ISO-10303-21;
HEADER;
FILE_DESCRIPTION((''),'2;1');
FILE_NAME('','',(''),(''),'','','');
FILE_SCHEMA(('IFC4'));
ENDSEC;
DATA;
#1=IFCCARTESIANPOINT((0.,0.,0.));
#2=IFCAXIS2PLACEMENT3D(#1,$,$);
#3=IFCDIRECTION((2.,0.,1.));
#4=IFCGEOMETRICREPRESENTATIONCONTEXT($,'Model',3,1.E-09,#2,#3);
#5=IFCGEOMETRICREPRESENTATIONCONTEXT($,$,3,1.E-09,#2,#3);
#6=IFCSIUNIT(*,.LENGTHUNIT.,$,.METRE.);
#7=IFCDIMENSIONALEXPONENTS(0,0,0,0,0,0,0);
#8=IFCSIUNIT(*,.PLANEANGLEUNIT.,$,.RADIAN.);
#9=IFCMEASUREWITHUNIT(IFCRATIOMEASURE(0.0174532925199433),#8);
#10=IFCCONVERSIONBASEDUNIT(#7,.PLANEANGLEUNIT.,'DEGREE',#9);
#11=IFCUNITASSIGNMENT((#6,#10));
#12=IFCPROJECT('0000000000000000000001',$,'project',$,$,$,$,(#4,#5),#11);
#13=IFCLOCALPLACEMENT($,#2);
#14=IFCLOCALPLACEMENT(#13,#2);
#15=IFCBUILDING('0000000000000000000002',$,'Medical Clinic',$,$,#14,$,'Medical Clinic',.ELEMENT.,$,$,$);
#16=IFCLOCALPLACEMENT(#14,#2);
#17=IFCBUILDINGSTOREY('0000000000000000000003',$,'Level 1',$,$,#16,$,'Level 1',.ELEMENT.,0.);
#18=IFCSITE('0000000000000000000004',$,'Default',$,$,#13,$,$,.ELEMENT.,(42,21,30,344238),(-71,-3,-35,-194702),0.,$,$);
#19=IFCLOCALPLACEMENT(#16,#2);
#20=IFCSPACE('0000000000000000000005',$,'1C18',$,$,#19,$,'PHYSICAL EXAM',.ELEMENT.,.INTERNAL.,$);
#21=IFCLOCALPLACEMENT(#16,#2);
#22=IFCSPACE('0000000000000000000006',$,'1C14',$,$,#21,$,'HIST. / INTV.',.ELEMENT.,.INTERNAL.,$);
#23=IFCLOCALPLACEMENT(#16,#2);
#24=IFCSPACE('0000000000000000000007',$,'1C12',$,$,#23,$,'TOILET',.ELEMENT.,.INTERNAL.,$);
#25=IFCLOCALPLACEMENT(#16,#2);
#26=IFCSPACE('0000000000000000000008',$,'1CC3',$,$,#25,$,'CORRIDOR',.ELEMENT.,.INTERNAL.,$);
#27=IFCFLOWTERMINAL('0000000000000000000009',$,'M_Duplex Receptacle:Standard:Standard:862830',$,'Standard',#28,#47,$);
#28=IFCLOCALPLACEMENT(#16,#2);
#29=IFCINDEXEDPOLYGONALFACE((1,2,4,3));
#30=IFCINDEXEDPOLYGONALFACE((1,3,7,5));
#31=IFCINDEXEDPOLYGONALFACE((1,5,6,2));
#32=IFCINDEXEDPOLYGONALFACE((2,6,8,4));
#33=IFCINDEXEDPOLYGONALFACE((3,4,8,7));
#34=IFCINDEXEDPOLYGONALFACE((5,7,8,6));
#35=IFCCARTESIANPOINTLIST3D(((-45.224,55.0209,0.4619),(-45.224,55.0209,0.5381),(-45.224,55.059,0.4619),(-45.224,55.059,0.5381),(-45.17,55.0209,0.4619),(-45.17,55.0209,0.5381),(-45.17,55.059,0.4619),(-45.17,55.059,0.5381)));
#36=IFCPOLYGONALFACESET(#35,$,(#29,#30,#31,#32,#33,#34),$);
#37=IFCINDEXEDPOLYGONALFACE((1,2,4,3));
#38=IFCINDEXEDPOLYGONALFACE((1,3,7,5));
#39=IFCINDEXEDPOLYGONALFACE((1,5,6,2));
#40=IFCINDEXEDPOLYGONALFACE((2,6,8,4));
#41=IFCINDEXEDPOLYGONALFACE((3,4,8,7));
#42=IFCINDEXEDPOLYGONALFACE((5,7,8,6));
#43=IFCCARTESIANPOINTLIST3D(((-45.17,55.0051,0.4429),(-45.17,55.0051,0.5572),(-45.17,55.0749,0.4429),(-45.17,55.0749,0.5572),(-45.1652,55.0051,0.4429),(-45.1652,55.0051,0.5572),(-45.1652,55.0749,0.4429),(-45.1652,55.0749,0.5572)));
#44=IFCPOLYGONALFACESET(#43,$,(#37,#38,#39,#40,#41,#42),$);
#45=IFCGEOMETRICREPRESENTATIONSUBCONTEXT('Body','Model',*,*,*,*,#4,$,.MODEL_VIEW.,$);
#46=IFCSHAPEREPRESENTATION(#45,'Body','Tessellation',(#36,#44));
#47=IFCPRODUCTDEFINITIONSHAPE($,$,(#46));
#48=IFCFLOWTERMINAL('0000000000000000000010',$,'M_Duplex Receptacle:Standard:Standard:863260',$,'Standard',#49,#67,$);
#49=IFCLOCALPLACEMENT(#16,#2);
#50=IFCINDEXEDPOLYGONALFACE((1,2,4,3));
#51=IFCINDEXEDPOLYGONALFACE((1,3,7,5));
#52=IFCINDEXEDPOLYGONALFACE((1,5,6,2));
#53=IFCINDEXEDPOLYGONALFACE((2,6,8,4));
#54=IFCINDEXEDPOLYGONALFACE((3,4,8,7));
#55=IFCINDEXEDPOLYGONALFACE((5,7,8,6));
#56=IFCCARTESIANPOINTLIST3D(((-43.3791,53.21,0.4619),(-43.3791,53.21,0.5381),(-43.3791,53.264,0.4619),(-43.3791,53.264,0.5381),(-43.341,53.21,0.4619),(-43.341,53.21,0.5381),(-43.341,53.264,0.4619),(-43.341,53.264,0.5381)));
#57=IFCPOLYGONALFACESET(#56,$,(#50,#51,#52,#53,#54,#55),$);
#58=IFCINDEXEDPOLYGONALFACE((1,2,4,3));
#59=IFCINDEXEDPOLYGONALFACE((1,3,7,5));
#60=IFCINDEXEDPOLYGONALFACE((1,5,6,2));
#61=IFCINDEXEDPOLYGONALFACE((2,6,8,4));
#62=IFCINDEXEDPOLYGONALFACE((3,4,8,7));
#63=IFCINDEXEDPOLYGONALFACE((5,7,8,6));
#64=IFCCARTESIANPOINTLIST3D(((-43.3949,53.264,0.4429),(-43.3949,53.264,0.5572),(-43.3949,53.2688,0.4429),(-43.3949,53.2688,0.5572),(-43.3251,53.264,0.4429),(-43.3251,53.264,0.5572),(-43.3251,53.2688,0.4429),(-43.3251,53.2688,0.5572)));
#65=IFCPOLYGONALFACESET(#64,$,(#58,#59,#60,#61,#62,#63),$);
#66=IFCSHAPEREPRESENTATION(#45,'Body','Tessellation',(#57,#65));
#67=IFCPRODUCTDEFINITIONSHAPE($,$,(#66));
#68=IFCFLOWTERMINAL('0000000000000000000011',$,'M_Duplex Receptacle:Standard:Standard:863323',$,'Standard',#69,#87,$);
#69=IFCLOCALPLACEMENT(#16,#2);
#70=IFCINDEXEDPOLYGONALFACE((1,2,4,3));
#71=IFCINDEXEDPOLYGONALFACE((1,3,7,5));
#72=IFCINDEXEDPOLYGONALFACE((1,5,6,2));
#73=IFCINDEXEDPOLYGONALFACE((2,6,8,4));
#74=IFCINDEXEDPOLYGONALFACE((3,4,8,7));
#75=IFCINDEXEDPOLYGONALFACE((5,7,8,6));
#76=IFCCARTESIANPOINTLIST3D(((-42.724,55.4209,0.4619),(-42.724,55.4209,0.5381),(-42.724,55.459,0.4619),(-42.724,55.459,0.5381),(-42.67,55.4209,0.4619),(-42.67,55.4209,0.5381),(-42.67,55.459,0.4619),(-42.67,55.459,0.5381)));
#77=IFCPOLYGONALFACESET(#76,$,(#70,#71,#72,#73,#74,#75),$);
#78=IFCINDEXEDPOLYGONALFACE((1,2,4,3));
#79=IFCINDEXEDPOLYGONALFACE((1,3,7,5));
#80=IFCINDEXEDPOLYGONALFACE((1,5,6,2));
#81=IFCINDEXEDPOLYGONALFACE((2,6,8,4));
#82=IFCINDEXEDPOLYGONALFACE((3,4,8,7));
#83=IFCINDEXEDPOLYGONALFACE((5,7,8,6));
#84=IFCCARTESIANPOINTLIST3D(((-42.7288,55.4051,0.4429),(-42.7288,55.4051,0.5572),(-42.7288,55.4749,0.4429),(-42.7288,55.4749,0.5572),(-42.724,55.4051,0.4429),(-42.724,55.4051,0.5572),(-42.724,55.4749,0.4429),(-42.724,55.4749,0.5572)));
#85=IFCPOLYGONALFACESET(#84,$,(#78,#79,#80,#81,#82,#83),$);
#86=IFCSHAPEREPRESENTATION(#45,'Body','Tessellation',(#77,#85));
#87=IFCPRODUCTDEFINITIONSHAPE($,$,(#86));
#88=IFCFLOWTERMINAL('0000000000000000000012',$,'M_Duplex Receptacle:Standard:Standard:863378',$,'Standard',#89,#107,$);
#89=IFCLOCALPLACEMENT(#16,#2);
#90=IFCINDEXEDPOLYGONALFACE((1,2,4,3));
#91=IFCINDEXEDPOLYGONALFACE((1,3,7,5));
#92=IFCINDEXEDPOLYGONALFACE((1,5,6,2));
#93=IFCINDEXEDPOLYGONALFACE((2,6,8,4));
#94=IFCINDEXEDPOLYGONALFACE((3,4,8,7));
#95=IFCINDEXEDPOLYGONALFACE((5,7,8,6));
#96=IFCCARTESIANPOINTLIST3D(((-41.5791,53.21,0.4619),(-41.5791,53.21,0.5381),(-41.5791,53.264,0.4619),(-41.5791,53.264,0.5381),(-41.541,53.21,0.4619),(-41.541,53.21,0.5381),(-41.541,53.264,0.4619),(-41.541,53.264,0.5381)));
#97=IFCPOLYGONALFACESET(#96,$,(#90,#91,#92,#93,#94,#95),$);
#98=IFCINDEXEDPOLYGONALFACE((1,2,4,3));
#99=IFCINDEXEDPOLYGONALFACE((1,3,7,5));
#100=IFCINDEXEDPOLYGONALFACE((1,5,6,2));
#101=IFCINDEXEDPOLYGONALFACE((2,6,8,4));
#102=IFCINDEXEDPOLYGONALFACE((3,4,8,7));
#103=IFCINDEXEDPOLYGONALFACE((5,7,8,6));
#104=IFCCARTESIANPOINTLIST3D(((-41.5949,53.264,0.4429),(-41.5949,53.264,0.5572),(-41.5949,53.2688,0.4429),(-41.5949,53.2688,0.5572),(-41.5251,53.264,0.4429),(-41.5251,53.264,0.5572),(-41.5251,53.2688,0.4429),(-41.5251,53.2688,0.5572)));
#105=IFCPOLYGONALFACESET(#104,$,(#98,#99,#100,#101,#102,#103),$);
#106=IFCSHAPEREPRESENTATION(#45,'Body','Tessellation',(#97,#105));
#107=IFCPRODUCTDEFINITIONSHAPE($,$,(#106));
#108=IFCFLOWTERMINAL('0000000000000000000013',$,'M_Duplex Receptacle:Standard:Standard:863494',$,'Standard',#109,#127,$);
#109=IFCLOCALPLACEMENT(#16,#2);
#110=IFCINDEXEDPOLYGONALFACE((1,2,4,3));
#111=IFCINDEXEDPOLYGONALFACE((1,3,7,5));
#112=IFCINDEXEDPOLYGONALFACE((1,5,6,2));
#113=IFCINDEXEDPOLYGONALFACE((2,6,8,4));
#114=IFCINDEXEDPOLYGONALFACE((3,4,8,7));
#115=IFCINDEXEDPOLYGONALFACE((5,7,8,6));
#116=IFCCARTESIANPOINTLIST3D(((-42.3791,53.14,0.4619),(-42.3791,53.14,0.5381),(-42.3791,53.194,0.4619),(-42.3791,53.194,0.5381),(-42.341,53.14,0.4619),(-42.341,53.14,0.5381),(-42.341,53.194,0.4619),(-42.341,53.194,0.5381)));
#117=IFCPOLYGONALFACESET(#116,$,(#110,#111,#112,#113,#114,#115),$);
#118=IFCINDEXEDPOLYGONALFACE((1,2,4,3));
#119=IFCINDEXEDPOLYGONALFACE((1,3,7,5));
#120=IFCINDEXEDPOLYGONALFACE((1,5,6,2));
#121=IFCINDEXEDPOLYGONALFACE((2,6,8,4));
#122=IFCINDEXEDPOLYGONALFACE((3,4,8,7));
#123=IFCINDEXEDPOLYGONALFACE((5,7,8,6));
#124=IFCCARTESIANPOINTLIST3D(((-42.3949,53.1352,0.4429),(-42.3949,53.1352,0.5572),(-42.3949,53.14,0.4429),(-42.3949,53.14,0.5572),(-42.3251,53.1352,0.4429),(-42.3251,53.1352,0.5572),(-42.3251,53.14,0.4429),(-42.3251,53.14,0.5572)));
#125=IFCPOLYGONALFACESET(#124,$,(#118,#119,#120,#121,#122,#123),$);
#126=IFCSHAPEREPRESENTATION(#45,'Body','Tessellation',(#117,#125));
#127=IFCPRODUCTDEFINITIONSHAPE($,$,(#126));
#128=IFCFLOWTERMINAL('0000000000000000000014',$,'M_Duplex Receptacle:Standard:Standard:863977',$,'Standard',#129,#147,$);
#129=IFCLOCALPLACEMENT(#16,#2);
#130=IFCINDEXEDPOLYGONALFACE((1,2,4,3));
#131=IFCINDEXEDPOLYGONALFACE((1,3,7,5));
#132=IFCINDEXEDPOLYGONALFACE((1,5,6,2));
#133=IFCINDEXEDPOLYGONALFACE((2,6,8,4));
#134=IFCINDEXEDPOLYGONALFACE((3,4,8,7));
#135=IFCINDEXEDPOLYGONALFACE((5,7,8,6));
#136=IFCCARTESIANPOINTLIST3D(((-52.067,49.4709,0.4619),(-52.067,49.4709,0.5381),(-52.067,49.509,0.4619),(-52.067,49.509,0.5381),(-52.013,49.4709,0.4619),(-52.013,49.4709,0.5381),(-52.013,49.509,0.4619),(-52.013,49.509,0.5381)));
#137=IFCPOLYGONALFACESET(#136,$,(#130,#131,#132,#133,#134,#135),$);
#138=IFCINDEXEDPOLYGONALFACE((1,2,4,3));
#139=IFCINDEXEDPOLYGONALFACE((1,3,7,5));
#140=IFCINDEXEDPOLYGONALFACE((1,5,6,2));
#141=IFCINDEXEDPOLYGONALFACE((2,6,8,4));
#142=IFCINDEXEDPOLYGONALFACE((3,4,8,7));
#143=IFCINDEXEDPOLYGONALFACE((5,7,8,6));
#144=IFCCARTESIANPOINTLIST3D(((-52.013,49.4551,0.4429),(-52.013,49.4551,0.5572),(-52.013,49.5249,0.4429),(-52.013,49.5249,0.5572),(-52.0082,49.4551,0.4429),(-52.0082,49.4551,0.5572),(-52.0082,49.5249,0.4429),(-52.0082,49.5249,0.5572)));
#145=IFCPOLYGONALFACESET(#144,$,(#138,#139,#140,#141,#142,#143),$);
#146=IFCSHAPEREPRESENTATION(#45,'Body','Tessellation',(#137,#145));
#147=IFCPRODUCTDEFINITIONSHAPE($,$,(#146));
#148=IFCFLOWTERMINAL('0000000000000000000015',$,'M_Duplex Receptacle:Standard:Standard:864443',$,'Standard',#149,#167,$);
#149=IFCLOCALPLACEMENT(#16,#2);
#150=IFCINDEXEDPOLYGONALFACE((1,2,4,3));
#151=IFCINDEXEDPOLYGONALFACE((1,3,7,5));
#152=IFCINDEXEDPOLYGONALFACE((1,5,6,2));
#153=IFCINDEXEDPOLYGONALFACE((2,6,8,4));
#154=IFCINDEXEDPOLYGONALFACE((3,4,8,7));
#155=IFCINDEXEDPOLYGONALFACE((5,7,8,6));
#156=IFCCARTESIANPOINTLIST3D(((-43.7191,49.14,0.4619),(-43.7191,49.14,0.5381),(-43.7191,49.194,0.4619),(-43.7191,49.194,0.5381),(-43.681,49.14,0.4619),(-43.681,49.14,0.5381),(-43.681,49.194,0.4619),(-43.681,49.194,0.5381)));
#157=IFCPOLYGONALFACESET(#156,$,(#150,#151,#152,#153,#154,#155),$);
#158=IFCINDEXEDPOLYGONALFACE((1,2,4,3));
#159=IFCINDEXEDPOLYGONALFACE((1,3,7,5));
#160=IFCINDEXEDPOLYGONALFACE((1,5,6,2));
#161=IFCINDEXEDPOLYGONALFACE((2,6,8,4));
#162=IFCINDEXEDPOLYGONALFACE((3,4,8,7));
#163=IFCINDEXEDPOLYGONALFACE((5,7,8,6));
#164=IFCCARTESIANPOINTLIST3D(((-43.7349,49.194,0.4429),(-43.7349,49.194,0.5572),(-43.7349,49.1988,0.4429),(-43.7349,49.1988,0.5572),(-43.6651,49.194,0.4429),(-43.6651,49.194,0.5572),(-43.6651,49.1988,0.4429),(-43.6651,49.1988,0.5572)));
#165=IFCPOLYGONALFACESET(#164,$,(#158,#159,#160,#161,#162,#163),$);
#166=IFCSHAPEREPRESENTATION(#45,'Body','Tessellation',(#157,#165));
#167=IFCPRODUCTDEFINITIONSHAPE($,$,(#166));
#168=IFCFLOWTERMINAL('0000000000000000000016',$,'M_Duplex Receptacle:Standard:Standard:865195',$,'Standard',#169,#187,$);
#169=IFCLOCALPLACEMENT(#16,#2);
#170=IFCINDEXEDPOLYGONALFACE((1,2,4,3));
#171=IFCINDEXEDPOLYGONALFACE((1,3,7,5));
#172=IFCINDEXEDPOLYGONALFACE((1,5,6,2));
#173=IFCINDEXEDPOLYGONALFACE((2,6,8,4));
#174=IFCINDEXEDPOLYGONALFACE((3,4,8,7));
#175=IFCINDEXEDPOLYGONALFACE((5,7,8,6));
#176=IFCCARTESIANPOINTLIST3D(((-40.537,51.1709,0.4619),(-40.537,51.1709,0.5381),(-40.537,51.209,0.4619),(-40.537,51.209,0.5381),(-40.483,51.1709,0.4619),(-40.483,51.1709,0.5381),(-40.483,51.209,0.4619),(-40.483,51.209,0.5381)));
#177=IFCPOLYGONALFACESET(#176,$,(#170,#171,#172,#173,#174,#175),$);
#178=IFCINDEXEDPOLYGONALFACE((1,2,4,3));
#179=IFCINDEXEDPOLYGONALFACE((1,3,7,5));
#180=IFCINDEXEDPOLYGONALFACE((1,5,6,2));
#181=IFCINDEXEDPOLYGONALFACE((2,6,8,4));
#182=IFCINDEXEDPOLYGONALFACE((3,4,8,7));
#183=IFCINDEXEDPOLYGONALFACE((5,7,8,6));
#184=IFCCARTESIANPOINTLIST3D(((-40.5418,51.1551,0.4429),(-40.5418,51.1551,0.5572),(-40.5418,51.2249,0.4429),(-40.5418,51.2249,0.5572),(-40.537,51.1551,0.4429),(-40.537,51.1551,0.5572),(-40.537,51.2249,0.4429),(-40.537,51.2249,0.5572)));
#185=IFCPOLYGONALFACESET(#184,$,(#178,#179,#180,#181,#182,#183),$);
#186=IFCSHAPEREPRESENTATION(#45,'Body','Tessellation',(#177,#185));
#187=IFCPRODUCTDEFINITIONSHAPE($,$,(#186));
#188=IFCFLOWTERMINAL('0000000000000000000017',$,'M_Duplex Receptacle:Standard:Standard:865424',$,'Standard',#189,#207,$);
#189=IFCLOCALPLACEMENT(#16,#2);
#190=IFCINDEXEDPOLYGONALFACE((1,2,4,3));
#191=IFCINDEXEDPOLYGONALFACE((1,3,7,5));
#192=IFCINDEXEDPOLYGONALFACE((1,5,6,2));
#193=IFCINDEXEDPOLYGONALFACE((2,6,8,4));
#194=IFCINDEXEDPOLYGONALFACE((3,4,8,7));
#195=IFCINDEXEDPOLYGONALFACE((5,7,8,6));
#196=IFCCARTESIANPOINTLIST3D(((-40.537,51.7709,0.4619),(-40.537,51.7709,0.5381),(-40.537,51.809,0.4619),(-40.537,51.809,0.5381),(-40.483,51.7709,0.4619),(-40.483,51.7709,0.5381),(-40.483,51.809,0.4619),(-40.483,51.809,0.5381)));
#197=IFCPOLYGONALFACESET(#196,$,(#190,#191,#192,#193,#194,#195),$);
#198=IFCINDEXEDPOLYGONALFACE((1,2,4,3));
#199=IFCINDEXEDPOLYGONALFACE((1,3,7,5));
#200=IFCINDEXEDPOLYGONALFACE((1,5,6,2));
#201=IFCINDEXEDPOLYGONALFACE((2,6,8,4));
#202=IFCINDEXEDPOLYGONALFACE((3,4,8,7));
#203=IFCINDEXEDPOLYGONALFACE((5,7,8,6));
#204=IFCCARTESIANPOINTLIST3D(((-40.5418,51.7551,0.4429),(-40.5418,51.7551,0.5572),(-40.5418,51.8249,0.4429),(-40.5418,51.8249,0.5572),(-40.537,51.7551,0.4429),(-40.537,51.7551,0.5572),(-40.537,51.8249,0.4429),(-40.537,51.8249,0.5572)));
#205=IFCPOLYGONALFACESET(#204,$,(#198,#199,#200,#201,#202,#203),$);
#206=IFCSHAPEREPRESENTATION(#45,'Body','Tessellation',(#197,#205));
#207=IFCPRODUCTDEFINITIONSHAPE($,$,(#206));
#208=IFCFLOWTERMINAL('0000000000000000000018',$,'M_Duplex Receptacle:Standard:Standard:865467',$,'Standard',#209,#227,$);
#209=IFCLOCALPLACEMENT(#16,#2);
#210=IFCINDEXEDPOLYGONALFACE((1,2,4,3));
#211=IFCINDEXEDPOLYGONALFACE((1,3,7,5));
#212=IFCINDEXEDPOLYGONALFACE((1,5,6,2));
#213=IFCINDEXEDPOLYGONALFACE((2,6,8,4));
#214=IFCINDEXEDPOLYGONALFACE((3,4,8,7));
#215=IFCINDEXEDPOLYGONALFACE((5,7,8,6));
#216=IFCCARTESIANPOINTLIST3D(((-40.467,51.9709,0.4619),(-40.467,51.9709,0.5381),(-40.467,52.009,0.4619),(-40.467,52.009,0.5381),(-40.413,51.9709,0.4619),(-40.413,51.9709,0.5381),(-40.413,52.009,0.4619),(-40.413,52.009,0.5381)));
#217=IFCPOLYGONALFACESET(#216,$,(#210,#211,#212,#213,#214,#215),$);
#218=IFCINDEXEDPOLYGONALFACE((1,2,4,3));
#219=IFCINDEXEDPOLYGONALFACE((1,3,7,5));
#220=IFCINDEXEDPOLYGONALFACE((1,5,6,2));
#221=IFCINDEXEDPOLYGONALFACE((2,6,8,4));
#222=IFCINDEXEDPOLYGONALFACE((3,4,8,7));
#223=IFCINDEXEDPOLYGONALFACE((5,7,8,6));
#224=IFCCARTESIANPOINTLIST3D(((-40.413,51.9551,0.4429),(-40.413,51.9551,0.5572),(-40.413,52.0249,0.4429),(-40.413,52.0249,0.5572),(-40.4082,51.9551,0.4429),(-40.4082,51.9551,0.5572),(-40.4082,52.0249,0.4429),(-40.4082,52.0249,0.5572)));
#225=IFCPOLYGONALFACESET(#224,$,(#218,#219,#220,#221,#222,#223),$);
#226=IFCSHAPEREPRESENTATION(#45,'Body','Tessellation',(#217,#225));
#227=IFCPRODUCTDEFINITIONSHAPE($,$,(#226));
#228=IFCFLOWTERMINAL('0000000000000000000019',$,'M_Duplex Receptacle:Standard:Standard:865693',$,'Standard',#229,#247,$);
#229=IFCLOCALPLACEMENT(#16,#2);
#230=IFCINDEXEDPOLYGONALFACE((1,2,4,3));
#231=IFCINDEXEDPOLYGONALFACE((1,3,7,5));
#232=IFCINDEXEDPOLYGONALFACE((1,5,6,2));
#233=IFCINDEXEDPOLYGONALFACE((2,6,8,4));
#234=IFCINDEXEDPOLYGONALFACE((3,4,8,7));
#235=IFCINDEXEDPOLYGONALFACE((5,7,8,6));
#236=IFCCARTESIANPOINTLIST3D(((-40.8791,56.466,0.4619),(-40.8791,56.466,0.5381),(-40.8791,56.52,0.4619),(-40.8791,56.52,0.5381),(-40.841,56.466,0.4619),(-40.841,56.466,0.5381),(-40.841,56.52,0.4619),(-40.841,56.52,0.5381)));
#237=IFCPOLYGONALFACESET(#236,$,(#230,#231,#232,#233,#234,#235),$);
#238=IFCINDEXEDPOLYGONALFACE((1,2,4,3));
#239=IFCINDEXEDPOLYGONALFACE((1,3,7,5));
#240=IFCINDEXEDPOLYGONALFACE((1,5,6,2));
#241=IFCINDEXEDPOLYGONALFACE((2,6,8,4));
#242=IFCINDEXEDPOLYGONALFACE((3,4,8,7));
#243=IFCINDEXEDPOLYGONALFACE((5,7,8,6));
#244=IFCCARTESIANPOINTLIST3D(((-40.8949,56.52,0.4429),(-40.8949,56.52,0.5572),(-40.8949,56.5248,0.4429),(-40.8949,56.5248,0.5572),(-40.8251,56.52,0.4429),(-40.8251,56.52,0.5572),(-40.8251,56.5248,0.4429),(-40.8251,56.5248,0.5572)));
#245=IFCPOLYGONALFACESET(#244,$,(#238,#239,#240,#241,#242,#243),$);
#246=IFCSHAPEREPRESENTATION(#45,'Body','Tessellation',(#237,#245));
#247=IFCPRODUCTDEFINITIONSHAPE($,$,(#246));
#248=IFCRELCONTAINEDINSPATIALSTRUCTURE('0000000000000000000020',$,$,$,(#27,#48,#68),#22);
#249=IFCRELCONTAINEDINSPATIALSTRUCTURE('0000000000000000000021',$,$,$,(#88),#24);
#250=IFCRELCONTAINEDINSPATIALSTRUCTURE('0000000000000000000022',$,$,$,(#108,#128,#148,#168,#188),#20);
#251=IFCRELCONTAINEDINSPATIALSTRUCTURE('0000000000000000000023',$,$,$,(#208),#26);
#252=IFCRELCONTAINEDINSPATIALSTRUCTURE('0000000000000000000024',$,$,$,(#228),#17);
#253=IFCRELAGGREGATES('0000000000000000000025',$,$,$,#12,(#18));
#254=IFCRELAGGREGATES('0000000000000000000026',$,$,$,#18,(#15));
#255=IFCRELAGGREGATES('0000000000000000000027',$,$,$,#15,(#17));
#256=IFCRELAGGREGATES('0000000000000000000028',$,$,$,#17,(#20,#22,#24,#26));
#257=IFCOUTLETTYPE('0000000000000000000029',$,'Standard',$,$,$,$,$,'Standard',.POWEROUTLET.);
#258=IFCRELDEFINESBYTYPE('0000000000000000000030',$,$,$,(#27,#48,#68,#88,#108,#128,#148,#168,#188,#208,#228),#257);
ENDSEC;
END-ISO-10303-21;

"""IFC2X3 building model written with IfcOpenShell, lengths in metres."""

from ifc_helpers import new_model, entity, si_unit, converted_unit, direction, frame, frame_2d, origin, origin_2d_with_axis, place, context, subcontext, project, spatial, rectangle, extrude, source, transform, mapped, type_object, type_shapes, element, save


model = new_model("IFC2X3")

# Units and contexts
model_context = context("Model", 3, precision=1e-09, world=origin(), true_north=direction((2.0, 0.0, 1.0)))
context_of_model = context(None, 3, precision=1e-09, world=origin(), true_north=direction((2.0, 0.0, 1.0)))
body_context = subcontext(model_context, "Body", "Model", "MODEL_VIEW")
ifc_project = project(units=[si_unit("LENGTHUNIT", "METRE"), converted_unit("PLANEANGLEUNIT", "DEGREE", entity("IfcRatioMeasure", 0.0174532925199433), si_unit("PLANEANGLEUNIT", "RADIAN"), dimensions=[0, 0, 0, 0, 0, 0, 0])], contexts=[model_context, context_of_model])

# Site, building, storey
site_placement = place(None, origin())
site = spatial("IfcSite", under=ifc_project, at=site_placement, Name="Default", CompositionType="ELEMENT", RefLatitude=(42, 21, 30, 344238), RefLongitude=(-71, -3, -35, -194702), RefElevation=0.0)
building_placement = place(site_placement, origin())
building = spatial("IfcBuilding", under=site, at=building_placement, Name="Medical Clinic", LongName="Medical Clinic", CompositionType="ELEMENT")
storey_placement = place(building_placement, origin())
storey = spatial("IfcBuildingStorey", under=building, at=storey_placement, Name="Level 1", LongName="Level 1", CompositionType="ELEMENT", Elevation=0.0)

# Shared definitions
outlet_type = type_object("IfcOutletType", Name="Standard", ElementType="Standard", PredefinedType="POWEROUTLET")
shared_shape_1 = source(origin(), body_context, "Body", "SweptSolid", [
    extrude(rectangle(XDim=0.0381, YDim=0.0762, at=origin_2d_with_axis()), frame((0.0, 0.0, -0.054), z_axis=(0.0, 0.0, 1.0), x_axis=(-1.0, 0.0, 0.0)), (0.0, 0.0, 1.0), 0.054),
    extrude(rectangle(XDim=0.0698, YDim=0.1143, at=frame_2d((0.0, 0.0), x_axis=(1.0, 0.0))), frame((0.0, 0.0, 0.0), z_axis=(0.0, 0.0, 1.0), x_axis=(-1.0, 0.0, 0.0)), (0.0, 0.0, 1.0), 0.0048),
])
type_shapes(outlet_type, [shared_shape_1])

# Shared definitions
space_1_placement = place(storey_placement, origin())
space_1 = spatial("IfcSpace", under=storey, at=space_1_placement, Name="1C18", LongName="PHYSICAL EXAM", CompositionType="ELEMENT", InteriorOrExteriorSpace="INTERNAL")

# Shared definitions
space_2_placement = place(storey_placement, origin())
space_2 = spatial("IfcSpace", under=storey, at=space_2_placement, Name="1C14", LongName="HIST. / INTV.", CompositionType="ELEMENT", InteriorOrExteriorSpace="INTERNAL")

# Flow terminals
for number, where, z_axis, x_axis, name in (
    (1, (-45.17, 55.04, 0.5), (1.0, 0.0, 0.0), (0.0, 1.0, 0.0), "M_Duplex Receptacle:Standard:Standard:862830"),
    (2, (-43.36, 53.264, 0.5), (0.0, 1.0, 0.0), (-1.0, 0.0, 0.0), "M_Duplex Receptacle:Standard:Standard:863260"),
    (3, (-42.724, 55.44, 0.5), (-1.0, 0.0, 0.0), (0.0, -1.0, 0.0), "M_Duplex Receptacle:Standard:Standard:863323"),
):
    element("IfcFlowTerminal", number, at=place(space_2_placement, frame(where, z_axis=z_axis, x_axis=x_axis)), inside=space_2, type_object=outlet_type, Name=name, ObjectType="Standard", context=body_context, shape_type="MappedRepresentation", body=[
        mapped(shared_shape_1, transform((0.0, 0.0, 0.0), scale=1.0)),
    ])

# Shared definitions
space_3_placement = place(storey_placement, origin())
space_3 = spatial("IfcSpace", under=storey, at=space_3_placement, Name="1C12", LongName="TOILET", CompositionType="ELEMENT", InteriorOrExteriorSpace="INTERNAL")

# Flow terminals
flow_terminal_1_placement = place(space_3_placement, frame((-41.56, 53.264, 0.5), z_axis=(0.0, 1.0, 0.0), x_axis=(-1.0, 0.0, 0.0)))
element("IfcFlowTerminal", 4, at=flow_terminal_1_placement, inside=space_3, type_object=outlet_type, Name="M_Duplex Receptacle:Standard:Standard:863378", ObjectType="Standard", context=body_context, shape_type="MappedRepresentation", body=[
    mapped(shared_shape_1, transform((0.0, 0.0, 0.0), scale=1.0)),
])
for number, where, z_axis, x_axis, name in (
    (5, (-42.36, 53.14, 0.5), (0.0, -1.0, 0.0), (1.0, 0.0, 0.0), "M_Duplex Receptacle:Standard:Standard:863494"),
    (6, (-52.013, 49.49, 0.5), (1.0, 0.0, 0.0), (0.0, 1.0, 0.0), "M_Duplex Receptacle:Standard:Standard:863977"),
    (7, (-43.7, 49.194, 0.5), (0.0, 1.0, 0.0), (-1.0, 0.0, 0.0), "M_Duplex Receptacle:Standard:Standard:864443"),
    (8, (-40.537, 51.19, 0.5), (-1.0, 0.0, 0.0), (0.0, -1.0, 0.0), "M_Duplex Receptacle:Standard:Standard:865195"),
    (9, (-40.537, 51.79, 0.5), (-1.0, 0.0, 0.0), (0.0, -1.0, 0.0), "M_Duplex Receptacle:Standard:Standard:865424"),
):
    element("IfcFlowTerminal", number, at=place(space_1_placement, frame(where, z_axis=z_axis, x_axis=x_axis)), inside=space_1, type_object=outlet_type, Name=name, ObjectType="Standard", context=body_context, shape_type="MappedRepresentation", body=[
        mapped(shared_shape_1, transform((0.0, 0.0, 0.0), scale=1.0)),
    ])

# Shared definitions
space_4_placement = place(storey_placement, origin())
space_4 = spatial("IfcSpace", under=storey, at=space_4_placement, Name="1CC3", LongName="CORRIDOR", CompositionType="ELEMENT", InteriorOrExteriorSpace="INTERNAL")

# Flow terminals
flow_terminal_2_placement = place(space_4_placement, frame((-40.413, 51.99, 0.5), z_axis=(1.0, 0.0, 0.0), x_axis=(0.0, 1.0, 0.0)))
element("IfcFlowTerminal", 10, at=flow_terminal_2_placement, inside=space_4, type_object=outlet_type, Name="M_Duplex Receptacle:Standard:Standard:865467", ObjectType="Standard", context=body_context, shape_type="MappedRepresentation", body=[
    mapped(shared_shape_1, transform((0.0, 0.0, 0.0), scale=1.0)),
])
flow_terminal_3_placement = place(storey_placement, frame((-40.86, 56.52, 0.5), z_axis=(0.0, 1.0, 0.0), x_axis=(-1.0, 0.0, 0.0)))
element("IfcFlowTerminal", 11, at=flow_terminal_3_placement, inside=storey, type_object=outlet_type, Name="M_Duplex Receptacle:Standard:Standard:865693", ObjectType="Standard", context=body_context, shape_type="MappedRepresentation", body=[
    mapped(shared_shape_1, transform((0.0, 0.0, 0.0), scale=1.0)),
])

save(model, "model.ifc")
